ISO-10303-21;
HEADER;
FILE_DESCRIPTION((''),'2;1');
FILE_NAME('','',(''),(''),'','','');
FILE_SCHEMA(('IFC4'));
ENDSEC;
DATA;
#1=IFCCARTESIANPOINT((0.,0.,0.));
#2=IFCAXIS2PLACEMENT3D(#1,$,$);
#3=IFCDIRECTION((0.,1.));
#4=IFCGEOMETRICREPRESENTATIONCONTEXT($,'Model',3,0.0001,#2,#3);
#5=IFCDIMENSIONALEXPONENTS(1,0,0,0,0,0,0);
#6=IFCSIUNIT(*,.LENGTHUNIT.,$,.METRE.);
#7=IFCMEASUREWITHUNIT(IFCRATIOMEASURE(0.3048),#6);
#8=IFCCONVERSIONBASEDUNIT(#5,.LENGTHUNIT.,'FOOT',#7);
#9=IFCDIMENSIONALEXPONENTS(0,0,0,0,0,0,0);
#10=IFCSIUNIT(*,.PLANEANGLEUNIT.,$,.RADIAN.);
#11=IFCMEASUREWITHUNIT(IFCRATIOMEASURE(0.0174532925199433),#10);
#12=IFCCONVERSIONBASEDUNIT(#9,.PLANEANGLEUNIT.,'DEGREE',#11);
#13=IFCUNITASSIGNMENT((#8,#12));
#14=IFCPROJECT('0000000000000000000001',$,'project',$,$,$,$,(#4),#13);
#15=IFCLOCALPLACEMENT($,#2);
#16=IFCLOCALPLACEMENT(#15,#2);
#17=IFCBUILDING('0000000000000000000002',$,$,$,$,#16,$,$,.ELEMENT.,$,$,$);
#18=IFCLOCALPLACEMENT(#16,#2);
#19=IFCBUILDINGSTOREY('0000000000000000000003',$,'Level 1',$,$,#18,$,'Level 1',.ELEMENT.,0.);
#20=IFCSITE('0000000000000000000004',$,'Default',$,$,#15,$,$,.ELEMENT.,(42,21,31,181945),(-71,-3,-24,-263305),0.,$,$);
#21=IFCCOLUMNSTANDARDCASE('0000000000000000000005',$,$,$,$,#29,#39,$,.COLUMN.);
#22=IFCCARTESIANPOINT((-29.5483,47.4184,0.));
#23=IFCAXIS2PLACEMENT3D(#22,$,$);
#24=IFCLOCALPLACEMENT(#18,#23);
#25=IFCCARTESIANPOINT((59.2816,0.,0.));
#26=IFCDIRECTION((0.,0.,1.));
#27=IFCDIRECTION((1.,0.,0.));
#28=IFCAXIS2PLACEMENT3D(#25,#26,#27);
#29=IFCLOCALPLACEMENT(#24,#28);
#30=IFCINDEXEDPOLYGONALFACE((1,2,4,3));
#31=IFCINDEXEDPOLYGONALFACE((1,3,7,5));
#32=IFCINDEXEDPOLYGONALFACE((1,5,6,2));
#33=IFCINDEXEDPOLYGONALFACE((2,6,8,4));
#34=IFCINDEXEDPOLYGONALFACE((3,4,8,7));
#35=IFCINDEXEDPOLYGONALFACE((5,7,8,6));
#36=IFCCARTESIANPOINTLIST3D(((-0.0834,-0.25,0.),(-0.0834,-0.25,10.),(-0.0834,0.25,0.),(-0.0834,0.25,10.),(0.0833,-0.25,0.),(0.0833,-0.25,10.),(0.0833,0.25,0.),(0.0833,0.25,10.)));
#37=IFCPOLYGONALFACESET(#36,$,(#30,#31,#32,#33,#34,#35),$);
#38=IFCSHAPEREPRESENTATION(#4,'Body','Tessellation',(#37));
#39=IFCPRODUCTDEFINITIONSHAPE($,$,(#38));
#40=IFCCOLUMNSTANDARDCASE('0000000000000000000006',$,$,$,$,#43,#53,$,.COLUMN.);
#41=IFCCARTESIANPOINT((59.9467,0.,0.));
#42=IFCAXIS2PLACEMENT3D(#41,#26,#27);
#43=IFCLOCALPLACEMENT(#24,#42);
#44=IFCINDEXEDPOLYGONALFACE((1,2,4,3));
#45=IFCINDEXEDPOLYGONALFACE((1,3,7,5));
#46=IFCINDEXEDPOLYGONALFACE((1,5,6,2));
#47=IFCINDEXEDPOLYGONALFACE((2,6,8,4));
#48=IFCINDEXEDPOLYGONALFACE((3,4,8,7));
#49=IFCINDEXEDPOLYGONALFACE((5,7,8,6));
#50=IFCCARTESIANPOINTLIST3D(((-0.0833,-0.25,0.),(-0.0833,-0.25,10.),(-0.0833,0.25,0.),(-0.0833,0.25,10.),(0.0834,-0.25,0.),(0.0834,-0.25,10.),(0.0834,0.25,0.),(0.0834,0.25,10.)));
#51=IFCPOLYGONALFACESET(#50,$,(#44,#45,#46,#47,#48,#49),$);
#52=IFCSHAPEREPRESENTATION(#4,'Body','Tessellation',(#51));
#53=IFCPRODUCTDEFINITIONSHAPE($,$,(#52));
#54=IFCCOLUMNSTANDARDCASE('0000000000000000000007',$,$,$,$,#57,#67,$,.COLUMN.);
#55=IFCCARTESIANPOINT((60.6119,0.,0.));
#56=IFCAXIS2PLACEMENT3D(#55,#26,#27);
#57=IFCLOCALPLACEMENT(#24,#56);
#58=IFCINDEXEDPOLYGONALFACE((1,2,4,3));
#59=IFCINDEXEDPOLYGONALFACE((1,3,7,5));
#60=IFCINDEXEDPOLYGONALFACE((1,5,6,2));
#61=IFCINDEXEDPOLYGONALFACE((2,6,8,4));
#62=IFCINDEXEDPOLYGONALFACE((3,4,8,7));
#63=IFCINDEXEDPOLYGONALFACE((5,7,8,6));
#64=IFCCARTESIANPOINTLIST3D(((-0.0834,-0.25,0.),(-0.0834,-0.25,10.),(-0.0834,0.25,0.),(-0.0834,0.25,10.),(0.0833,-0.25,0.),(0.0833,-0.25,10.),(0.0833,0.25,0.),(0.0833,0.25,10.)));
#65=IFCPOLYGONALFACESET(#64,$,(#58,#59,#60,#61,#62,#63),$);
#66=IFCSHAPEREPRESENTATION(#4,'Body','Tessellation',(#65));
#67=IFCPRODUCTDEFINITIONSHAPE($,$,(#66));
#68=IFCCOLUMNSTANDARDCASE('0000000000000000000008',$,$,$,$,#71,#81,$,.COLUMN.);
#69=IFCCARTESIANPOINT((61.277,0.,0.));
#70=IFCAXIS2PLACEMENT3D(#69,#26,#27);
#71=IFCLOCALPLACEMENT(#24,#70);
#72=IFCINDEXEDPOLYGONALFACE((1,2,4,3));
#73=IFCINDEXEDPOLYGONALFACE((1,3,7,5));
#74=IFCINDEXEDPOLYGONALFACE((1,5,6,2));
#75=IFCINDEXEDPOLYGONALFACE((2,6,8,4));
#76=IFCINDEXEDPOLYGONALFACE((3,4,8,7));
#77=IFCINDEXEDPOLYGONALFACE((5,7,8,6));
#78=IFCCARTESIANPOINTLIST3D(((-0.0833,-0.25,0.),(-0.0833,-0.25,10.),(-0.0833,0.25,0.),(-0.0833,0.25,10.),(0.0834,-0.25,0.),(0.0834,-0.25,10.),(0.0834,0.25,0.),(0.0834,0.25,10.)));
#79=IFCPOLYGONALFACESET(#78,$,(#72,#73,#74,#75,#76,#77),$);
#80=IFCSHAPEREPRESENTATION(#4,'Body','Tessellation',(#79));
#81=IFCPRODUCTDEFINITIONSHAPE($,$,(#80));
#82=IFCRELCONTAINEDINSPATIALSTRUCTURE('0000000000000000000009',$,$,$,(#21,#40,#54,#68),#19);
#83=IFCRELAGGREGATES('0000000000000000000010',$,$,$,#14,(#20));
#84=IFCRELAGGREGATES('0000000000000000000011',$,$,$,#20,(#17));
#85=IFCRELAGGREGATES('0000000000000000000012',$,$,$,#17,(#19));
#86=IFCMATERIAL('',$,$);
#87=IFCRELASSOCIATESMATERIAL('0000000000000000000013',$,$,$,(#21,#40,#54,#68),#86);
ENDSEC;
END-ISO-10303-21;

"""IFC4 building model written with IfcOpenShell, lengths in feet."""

from ifc_helpers import new_model, entity, si_unit, converted_unit, direction, frame, origin, place, context, project, spatial, rectangle, extrude, material, element, save


model = new_model("IFC4")

# Units and contexts
model_context = context("Model", 3, precision=0.0001, world=origin(), true_north=direction((0.0, 1.0)))
ifc_project = project(units=[converted_unit("LENGTHUNIT", "FOOT", entity("IfcRatioMeasure", 0.3048), si_unit("LENGTHUNIT", "METRE"), dimensions=[1, 0, 0, 0, 0, 0, 0]), converted_unit("PLANEANGLEUNIT", "DEGREE", entity("IfcRatioMeasure", 0.0174532925199433), si_unit("PLANEANGLEUNIT", "RADIAN"), dimensions=[0, 0, 0, 0, 0, 0, 0])], contexts=[model_context])

# Site, building, storey
site_placement = place(None, origin())
site = spatial("IfcSite", under=ifc_project, at=site_placement, Name="Default", CompositionType="ELEMENT", RefLatitude=(42, 21, 31, 181945), RefLongitude=(-71, -3, -24, -263305), RefElevation=0.0)
building_placement = place(site_placement, origin())
building = spatial("IfcBuilding", under=site, at=building_placement, CompositionType="ELEMENT")
storey_placement = place(building_placement, origin())
storey = spatial("IfcBuildingStorey", under=building, at=storey_placement, Name="Level 1", LongName="Level 1", CompositionType="ELEMENT", Elevation=0.0)

# Columns
ifc_material = material(Name="")
placement = place(storey_placement, frame((-29.5483, 47.4184, 0.0)))
for number, where, z_axis, x_axis in (
    (1, (59.2816, 0.0, 0.0), (0.0, 0.0, 1.0), (1.0, 0.0, 0.0)),
    (2, (59.9467, 0.0, 0.0), (0.0, 0.0, 1.0), (1.0, 0.0, 0.0)),
    (3, (60.6119, 0.0, 0.0), (0.0, 0.0, 1.0), (1.0, 0.0, 0.0)),
    (4, (61.277, 0.0, 0.0), (0.0, 0.0, 1.0), (1.0, 0.0, 0.0)),
):
    element("IfcColumnStandardCase", number, at=place(placement, frame(where, z_axis=z_axis, x_axis=x_axis)), inside=storey, material=ifc_material, PredefinedType="COLUMN", context=model_context, shape_type="SweptSolid", body=[
        extrude(rectangle(XDim=0.1667, YDim=0.5), origin(), (0.0, 0.0, 1.0), 10.0),
    ])

save(model, "model.ifc")
